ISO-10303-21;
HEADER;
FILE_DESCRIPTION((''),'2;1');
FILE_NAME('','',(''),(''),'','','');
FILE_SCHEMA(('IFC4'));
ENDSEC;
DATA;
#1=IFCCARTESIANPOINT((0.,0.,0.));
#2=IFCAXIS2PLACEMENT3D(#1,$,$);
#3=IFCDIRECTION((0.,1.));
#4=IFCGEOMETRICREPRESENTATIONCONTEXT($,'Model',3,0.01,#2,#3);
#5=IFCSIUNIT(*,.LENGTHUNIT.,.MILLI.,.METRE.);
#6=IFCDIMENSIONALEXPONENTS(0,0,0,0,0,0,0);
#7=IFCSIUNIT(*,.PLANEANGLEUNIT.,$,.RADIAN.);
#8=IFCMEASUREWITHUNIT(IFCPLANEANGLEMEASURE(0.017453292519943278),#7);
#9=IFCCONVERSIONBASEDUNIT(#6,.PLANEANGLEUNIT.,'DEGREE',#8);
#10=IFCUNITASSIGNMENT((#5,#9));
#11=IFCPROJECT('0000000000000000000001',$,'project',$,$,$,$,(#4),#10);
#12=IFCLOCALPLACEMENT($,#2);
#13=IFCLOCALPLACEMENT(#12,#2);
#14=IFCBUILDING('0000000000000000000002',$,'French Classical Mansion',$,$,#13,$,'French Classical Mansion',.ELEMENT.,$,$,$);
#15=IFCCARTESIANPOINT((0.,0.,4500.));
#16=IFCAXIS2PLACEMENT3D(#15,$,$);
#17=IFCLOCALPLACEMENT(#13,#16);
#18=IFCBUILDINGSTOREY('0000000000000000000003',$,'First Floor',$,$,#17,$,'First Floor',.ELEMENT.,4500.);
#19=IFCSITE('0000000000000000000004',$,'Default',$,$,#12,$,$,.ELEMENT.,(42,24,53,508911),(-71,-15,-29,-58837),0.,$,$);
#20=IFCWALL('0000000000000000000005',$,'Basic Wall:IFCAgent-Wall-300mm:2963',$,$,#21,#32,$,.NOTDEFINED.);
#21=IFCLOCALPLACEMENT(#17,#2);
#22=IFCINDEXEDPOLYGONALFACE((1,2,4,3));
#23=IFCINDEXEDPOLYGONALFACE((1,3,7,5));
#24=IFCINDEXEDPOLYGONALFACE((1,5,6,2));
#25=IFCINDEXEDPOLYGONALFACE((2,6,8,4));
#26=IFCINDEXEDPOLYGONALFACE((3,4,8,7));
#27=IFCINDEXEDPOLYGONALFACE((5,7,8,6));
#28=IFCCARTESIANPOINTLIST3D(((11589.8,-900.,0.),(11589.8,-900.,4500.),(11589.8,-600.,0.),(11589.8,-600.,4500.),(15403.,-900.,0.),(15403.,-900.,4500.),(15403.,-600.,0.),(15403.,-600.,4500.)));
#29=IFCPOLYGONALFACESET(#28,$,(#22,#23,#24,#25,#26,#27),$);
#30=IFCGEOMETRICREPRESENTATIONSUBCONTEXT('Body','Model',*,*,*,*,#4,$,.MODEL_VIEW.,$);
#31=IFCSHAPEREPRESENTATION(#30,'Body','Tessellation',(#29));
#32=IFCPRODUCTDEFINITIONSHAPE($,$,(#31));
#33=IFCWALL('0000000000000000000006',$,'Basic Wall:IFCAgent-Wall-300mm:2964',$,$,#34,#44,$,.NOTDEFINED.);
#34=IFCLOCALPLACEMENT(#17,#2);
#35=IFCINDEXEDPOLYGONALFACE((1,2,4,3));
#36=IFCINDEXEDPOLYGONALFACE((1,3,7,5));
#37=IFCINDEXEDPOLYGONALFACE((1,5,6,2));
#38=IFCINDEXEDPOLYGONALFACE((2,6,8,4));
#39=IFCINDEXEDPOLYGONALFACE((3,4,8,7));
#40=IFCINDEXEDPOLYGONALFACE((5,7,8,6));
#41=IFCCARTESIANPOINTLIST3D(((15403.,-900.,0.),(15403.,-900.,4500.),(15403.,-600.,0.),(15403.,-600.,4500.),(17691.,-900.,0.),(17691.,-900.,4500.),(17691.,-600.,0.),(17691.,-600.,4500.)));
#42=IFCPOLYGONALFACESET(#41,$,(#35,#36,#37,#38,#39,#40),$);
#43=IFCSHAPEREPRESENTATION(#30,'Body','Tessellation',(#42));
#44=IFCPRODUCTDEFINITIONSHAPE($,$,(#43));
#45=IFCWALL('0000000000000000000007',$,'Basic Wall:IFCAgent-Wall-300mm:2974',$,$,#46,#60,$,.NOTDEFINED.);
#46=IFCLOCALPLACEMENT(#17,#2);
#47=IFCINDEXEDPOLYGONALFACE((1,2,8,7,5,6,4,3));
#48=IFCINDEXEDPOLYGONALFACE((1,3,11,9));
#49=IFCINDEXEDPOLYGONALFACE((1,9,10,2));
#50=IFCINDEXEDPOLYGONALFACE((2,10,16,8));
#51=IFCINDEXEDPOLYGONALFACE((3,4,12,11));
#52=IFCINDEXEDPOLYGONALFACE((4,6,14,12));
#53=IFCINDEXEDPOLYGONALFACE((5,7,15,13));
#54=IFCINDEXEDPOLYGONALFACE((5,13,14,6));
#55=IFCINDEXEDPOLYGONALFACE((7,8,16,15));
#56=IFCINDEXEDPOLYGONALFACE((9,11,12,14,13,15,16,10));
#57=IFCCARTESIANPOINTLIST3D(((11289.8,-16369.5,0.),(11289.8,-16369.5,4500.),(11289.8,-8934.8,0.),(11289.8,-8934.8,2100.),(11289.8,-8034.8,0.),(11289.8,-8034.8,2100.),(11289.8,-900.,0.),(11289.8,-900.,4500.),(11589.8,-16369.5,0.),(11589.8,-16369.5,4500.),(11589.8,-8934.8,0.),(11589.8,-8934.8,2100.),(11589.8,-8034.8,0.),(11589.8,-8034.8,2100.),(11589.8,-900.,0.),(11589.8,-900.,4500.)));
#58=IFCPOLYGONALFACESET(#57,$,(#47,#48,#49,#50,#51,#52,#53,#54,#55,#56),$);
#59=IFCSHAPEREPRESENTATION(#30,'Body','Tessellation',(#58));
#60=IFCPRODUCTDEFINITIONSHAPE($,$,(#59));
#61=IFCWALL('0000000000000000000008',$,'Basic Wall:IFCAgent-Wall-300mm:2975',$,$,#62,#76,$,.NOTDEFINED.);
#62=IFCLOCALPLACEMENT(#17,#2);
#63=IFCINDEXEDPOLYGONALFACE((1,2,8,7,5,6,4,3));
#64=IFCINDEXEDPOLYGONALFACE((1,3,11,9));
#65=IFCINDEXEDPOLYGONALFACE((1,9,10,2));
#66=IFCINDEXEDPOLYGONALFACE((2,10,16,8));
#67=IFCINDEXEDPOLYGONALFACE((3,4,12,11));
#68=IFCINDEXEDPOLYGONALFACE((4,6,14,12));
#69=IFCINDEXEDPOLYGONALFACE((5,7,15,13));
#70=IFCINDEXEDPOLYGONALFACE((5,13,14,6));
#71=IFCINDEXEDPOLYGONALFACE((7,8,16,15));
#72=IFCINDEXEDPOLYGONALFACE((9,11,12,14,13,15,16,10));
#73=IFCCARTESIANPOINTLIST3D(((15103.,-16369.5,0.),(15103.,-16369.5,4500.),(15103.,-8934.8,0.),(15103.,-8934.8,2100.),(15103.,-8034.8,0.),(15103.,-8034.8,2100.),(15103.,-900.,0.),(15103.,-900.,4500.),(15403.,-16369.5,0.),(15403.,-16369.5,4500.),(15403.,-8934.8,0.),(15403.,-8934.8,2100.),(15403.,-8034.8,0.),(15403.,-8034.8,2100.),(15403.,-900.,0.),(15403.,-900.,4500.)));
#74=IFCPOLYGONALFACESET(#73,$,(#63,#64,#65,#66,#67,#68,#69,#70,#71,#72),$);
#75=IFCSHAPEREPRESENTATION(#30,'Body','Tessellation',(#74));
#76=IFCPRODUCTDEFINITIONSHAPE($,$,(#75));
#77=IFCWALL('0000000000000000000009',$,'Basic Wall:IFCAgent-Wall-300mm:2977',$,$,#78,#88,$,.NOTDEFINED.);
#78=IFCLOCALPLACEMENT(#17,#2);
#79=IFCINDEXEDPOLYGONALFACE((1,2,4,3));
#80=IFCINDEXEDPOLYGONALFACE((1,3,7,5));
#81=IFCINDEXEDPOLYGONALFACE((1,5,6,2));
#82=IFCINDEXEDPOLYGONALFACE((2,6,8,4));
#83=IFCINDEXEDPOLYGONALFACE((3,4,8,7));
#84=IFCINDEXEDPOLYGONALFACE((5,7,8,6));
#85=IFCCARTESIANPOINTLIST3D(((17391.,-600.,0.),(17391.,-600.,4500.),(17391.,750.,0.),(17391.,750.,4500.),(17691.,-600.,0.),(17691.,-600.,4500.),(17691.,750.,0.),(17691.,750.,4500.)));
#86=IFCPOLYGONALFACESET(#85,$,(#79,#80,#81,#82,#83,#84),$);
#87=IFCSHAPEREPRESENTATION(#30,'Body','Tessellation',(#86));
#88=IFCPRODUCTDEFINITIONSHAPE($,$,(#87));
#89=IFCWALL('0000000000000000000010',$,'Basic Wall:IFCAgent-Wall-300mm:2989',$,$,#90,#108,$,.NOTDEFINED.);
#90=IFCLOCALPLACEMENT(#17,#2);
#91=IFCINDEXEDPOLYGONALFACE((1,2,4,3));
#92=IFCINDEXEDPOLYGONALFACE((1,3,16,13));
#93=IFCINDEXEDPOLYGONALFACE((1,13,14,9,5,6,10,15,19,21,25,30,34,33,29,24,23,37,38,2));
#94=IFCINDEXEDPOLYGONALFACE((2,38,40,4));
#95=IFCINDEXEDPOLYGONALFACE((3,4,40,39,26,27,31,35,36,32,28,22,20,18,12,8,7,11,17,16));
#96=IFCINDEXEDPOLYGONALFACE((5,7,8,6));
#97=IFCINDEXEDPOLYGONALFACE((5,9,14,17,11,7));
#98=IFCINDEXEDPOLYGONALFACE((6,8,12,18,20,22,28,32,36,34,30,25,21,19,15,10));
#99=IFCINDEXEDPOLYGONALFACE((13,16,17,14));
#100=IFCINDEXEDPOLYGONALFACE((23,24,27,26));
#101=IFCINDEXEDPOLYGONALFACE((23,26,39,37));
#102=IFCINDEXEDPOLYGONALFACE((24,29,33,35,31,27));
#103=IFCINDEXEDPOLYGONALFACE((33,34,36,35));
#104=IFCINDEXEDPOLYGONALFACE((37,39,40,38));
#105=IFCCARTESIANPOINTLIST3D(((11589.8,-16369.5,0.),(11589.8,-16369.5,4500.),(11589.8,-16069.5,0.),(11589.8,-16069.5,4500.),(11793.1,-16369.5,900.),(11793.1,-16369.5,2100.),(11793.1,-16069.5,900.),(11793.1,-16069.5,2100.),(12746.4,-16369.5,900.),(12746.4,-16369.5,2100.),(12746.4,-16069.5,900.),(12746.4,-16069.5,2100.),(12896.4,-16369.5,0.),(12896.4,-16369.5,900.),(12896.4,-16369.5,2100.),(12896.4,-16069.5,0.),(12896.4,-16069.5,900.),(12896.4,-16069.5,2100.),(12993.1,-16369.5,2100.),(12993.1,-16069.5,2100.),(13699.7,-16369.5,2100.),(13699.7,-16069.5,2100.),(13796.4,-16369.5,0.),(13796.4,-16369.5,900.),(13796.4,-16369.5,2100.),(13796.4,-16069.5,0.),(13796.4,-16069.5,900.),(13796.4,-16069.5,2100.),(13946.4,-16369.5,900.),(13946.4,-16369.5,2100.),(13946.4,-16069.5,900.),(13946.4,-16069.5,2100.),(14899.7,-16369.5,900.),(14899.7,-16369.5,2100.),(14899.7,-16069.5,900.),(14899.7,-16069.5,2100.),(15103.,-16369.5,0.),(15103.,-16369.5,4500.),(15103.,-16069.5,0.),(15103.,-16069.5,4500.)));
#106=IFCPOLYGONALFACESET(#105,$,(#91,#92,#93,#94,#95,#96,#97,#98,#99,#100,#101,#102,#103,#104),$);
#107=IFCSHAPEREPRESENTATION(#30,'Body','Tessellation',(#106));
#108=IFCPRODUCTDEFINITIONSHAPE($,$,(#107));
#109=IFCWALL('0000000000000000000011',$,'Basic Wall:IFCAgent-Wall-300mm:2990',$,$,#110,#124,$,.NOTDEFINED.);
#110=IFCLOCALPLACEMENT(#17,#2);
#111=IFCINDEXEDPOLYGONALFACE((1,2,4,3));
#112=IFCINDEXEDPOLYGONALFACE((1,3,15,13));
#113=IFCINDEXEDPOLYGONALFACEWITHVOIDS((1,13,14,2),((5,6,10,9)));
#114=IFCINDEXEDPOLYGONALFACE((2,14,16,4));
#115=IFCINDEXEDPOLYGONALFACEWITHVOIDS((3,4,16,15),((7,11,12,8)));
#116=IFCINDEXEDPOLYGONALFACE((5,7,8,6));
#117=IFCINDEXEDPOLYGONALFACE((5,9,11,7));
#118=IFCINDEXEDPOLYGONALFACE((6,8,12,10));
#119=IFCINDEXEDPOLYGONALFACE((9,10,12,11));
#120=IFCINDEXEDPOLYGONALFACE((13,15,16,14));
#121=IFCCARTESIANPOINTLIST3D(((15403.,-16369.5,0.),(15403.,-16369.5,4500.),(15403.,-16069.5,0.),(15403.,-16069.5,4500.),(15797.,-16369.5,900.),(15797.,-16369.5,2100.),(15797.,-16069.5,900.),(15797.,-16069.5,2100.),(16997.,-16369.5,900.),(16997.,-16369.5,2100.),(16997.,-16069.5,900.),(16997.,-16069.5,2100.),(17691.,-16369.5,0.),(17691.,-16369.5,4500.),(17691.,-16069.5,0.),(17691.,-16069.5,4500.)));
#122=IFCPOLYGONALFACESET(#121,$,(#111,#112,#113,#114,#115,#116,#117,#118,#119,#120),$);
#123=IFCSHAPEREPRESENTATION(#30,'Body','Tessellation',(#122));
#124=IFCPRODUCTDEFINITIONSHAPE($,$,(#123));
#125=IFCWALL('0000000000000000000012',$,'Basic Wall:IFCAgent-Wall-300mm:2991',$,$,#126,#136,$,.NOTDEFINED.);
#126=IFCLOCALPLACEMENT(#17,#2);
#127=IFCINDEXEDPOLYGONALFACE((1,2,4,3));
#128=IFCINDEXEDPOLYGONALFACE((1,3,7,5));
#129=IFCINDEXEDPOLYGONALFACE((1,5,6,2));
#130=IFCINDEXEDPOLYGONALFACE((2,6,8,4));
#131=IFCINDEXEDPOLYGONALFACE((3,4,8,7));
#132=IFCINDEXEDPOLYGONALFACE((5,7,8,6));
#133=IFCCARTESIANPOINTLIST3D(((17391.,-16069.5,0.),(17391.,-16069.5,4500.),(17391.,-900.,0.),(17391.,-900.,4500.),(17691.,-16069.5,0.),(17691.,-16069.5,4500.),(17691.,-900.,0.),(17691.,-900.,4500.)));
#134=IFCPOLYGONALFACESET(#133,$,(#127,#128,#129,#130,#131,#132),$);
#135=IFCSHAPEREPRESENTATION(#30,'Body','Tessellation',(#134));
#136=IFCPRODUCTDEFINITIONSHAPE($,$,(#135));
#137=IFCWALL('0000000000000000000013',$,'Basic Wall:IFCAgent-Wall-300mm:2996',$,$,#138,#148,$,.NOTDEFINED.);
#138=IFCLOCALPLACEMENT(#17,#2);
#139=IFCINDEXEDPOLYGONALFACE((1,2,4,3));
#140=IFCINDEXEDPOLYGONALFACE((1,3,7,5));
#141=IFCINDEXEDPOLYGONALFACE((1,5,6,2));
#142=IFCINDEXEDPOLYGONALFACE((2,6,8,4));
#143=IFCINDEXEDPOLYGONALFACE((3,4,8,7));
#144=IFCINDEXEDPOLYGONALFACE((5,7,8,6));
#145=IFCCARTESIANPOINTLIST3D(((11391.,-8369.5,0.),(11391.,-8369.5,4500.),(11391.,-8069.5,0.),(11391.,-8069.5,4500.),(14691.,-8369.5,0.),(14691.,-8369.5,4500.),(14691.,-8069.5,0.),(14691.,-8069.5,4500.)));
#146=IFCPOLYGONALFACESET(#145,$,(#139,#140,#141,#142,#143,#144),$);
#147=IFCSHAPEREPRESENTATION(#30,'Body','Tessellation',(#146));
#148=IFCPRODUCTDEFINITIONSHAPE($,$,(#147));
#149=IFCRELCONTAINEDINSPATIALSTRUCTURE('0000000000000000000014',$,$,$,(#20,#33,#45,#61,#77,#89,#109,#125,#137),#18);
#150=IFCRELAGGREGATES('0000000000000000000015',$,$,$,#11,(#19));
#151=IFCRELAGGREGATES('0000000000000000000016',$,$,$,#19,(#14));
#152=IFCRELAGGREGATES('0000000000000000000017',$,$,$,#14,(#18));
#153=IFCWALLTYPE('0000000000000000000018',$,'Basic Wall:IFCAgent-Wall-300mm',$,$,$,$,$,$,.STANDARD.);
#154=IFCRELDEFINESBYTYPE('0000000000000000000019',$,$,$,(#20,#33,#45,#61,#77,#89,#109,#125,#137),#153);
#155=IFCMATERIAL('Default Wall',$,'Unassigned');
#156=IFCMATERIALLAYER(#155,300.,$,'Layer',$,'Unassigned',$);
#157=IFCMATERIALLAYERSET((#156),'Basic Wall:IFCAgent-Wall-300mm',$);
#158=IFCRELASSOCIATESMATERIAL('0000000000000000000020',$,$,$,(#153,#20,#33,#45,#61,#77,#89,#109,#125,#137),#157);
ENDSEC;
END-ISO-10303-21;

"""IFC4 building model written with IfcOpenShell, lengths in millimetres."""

from ifc_helpers import new_model, entity, si_unit, converted_unit, direction, frame, frame_2d, origin, place, context, subcontext, project, spatial, rectangle, extrude, material, layer, layer_set, layer_usage, type_object, element, save


model = new_model("IFC4")

# Units and contexts
model_context = context("Model", 3, precision=0.01, world=origin(), true_north=direction((0.0, 1.0)))
body_context = subcontext(model_context, "Body", "Model", "MODEL_VIEW")
ifc_project = project(units=[si_unit("LENGTHUNIT", "METRE", prefix="MILLI"), converted_unit("PLANEANGLEUNIT", "DEGREE", entity("IfcPlaneAngleMeasure", 0.017453292519943278), si_unit("PLANEANGLEUNIT", "RADIAN"), dimensions=[0, 0, 0, 0, 0, 0, 0])], contexts=[model_context])

# Site, building, storey
site_placement = place(None, origin())
site = spatial("IfcSite", under=ifc_project, at=site_placement, Name="Default", CompositionType="ELEMENT", RefLatitude=(42, 24, 53, 508911), RefLongitude=(-71, -15, -29, -58837), RefElevation=0.0)
building_placement = place(site_placement, origin())
building = spatial("IfcBuilding", under=site, at=building_placement, Name="French Classical Mansion", LongName="French Classical Mansion", CompositionType="ELEMENT")
storey_placement = place(building_placement, frame((0.0, 0.0, 4500.0)))
storey = spatial("IfcBuildingStorey", under=building, at=storey_placement, Name="First Floor", LongName="First Floor", CompositionType="ELEMENT", Elevation=4500.0)

# Walls
ifc_material = material(Name="Default Wall", Category="Unassigned")
ifc_layer = layer(ifc_material, 300.0, Name="Layer", Category="Unassigned")
ifc_layer_set = layer_set([ifc_layer], Name="Basic Wall:IFCAgent-Wall-300mm")
ifc_layer_usage_1 = layer_usage(ifc_layer_set, "AXIS2", "NEGATIVE", 150.0)
wall_type = type_object("IfcWallType", Name="Basic Wall:IFCAgent-Wall-300mm", PredefinedType="STANDARD", material=ifc_layer_set)
wall_1_placement = place(storey_placement, frame((11589.8, -750.0, 0.0)))
element("IfcWall", 1, at=wall_1_placement, inside=storey, type_object=wall_type, material=ifc_layer_usage_1, Name="Basic Wall:IFCAgent-Wall-300mm:2963", PredefinedType="NOTDEFINED", context=body_context, shape_type="SweptSolid", body=[
    extrude(rectangle(XDim=3813.3, YDim=300.0, at=frame_2d((1906.6, 0.0), x_axis=(-1.0, 0.0))), origin(), (0.0, 0.0, 1.0), 4500.0),
])
ifc_layer_usage_2 = layer_usage(ifc_layer_set, "AXIS2", "NEGATIVE", 150.0)
wall_2_placement = place(storey_placement, frame((15403.0, -750.0, 0.0)))
element("IfcWall", 2, at=wall_2_placement, inside=storey, type_object=wall_type, material=ifc_layer_usage_2, Name="Basic Wall:IFCAgent-Wall-300mm:2964", PredefinedType="NOTDEFINED", context=body_context, shape_type="SweptSolid", body=[
    extrude(rectangle(XDim=2288.0, YDim=300.0, at=frame_2d((1144.0, 0.0), x_axis=(-1.0, 0.0))), origin(), (0.0, 0.0, 1.0), 4500.0),
])

# Walls, openings
ifc_layer_usage_3 = layer_usage(ifc_layer_set, "AXIS2", "NEGATIVE", 150.0)
wall_3_placement = place(storey_placement, frame((11439.8, -16369.5, 0.0), z_axis=(0.0, 0.0, 1.0), x_axis=(0.0, 1.0, 0.0)))
wall_3 = element("IfcWall", 3, at=wall_3_placement, inside=storey, type_object=wall_type, material=ifc_layer_usage_3, Name="Basic Wall:IFCAgent-Wall-300mm:2974", PredefinedType="NOTDEFINED", context=body_context, shape_type="SweptSolid", body=[
    extrude(rectangle(XDim=15469.5, YDim=300.0, at=frame_2d((7734.8, 0.0), x_axis=(-1.0, 0.0))), origin(), (0.0, 0.0, 1.0), 4500.0),
])
opening_1_placement = place(wall_3_placement, origin())
element("IfcOpeningElement", 4, at=opening_1_placement, cuts=wall_3, PredefinedType="OPENING", context=body_context, shape_type="SweptSolid", body=[
    extrude(rectangle(XDim=2100.0, YDim=900.0, at=frame_2d((0.0, 0.0), x_axis=(1.0, 0.0))), frame((7884.7, -150.0, 1050.0), z_axis=(0.0, 1.0, 0.0), x_axis=(0.0, 0.0, -1.0)), (0.0, 0.0, 1.0), 300.0),
])
ifc_layer_usage_4 = layer_usage(ifc_layer_set, "AXIS2", "NEGATIVE", 150.0)
wall_4_placement = place(storey_placement, frame((15253.0, -16369.5, 0.0), z_axis=(0.0, 0.0, 1.0), x_axis=(0.0, 1.0, 0.0)))
wall_4 = element("IfcWall", 5, at=wall_4_placement, inside=storey, type_object=wall_type, material=ifc_layer_usage_4, Name="Basic Wall:IFCAgent-Wall-300mm:2975", PredefinedType="NOTDEFINED", context=body_context, shape_type="SweptSolid", body=[
    extrude(rectangle(XDim=15469.5, YDim=300.0, at=frame_2d((7734.8, 0.0), x_axis=(-1.0, 0.0))), origin(), (0.0, 0.0, 1.0), 4500.0),
])
opening_2_placement = place(wall_4_placement, origin())
element("IfcOpeningElement", 6, at=opening_2_placement, cuts=wall_4, PredefinedType="OPENING", context=body_context, shape_type="SweptSolid", body=[
    extrude(rectangle(XDim=2100.0, YDim=900.0, at=frame_2d((0.0, 0.0), x_axis=(1.0, 0.0))), frame((7884.7, -150.0, 1050.0), z_axis=(0.0, 1.0, 0.0), x_axis=(0.0, 0.0, -1.0)), (0.0, 0.0, 1.0), 300.0),
])

# Wall
ifc_layer_usage_5 = layer_usage(ifc_layer_set, "AXIS2", "NEGATIVE", 150.0)
wall_5_placement = place(storey_placement, frame((17541.0, -600.0, 0.0), z_axis=(0.0, 0.0, 1.0), x_axis=(0.0, 1.0, 0.0)))
element("IfcWall", 7, at=wall_5_placement, inside=storey, type_object=wall_type, material=ifc_layer_usage_5, Name="Basic Wall:IFCAgent-Wall-300mm:2977", PredefinedType="NOTDEFINED", context=body_context, shape_type="SweptSolid", body=[
    extrude(rectangle(XDim=1350.0, YDim=300.0, at=frame_2d((675.0, 0.0), x_axis=(-1.0, 0.0))), origin(), (0.0, 0.0, 1.0), 4500.0),
])

# Wall, openings
ifc_layer_usage_6 = layer_usage(ifc_layer_set, "AXIS2", "NEGATIVE", 150.0)
wall_6_placement = place(storey_placement, frame((11589.8, -16219.5, 0.0)))
wall_6 = element("IfcWall", 8, at=wall_6_placement, inside=storey, type_object=wall_type, material=ifc_layer_usage_6, Name="Basic Wall:IFCAgent-Wall-300mm:2989", PredefinedType="NOTDEFINED", context=body_context, shape_type="SweptSolid", body=[
    extrude(rectangle(XDim=3513.3, YDim=300.0, at=frame_2d((1756.6, 0.0), x_axis=(-1.0, 0.0))), origin(), (0.0, 0.0, 1.0), 4500.0),
])
opening_3_placement = place(wall_6_placement, origin())
element("IfcOpeningElement", 9, at=opening_3_placement, cuts=wall_6, PredefinedType="OPENING", context=body_context, shape_type="SweptSolid", body=[
    extrude(rectangle(XDim=2100.0, YDim=900.0, at=frame_2d((0.0, 0.0), x_axis=(1.0, 0.0))), frame((1756.6, -150.0, 1050.0), z_axis=(0.0, 1.0, 0.0), x_axis=(0.0, 0.0, -1.0)), (0.0, 0.0, 1.0), 300.0),
])
opening_4_placement = place(wall_6_placement, origin())
element("IfcOpeningElement", 10, at=opening_4_placement, cuts=wall_6, PredefinedType="OPENING", context=body_context, shape_type="SweptSolid", body=[
    extrude(rectangle(XDim=1200.0, YDim=1200.0, at=frame_2d((0.0, 0.0), x_axis=(1.0, 0.0))), frame((803.3, -150.0, 1500.0), z_axis=(0.0, 1.0, 0.0), x_axis=(0.0, 0.0, -1.0)), (0.0, 0.0, 1.0), 300.0),
])
opening_5_placement = place(wall_6_placement, origin())
element("IfcOpeningElement", 11, at=opening_5_placement, cuts=wall_6, PredefinedType="OPENING", context=body_context, shape_type="SweptSolid", body=[
    extrude(rectangle(XDim=1200.0, YDim=1200.0, at=frame_2d((0.0, 0.0), x_axis=(1.0, 0.0))), frame((1756.6, -150.0, 1500.0), z_axis=(0.0, 1.0, 0.0), x_axis=(0.0, 0.0, -1.0)), (0.0, 0.0, 1.0), 300.0),
])
opening_6_placement = place(wall_6_placement, origin())
element("IfcOpeningElement", 12, at=opening_6_placement, cuts=wall_6, PredefinedType="OPENING", context=body_context, shape_type="SweptSolid", body=[
    extrude(rectangle(XDim=1200.0, YDim=1200.0, at=frame_2d((0.0, 0.0), x_axis=(1.0, 0.0))), frame((2709.9, -150.0, 1500.0), z_axis=(0.0, 1.0, 0.0), x_axis=(0.0, 0.0, -1.0)), (0.0, 0.0, 1.0), 300.0),
])

# Wall, opening
ifc_layer_usage_7 = layer_usage(ifc_layer_set, "AXIS2", "NEGATIVE", 150.0)
wall_7_placement = place(storey_placement, frame((15403.0, -16219.5, 0.0)))
wall_7 = element("IfcWall", 13, at=wall_7_placement, inside=storey, type_object=wall_type, material=ifc_layer_usage_7, Name="Basic Wall:IFCAgent-Wall-300mm:2990", PredefinedType="NOTDEFINED", context=body_context, shape_type="SweptSolid", body=[
    extrude(rectangle(XDim=2288.0, YDim=300.0, at=frame_2d((1144.0, 0.0), x_axis=(-1.0, 0.0))), origin(), (0.0, 0.0, 1.0), 4500.0),
])
opening_7_placement = place(wall_7_placement, origin())
element("IfcOpeningElement", 14, at=opening_7_placement, cuts=wall_7, PredefinedType="OPENING", context=body_context, shape_type="SweptSolid", body=[
    extrude(rectangle(XDim=1200.0, YDim=1200.0, at=frame_2d((0.0, 0.0), x_axis=(1.0, 0.0))), frame((994.0, -150.0, 1500.0), z_axis=(0.0, 1.0, 0.0), x_axis=(0.0, 0.0, -1.0)), (0.0, 0.0, 1.0), 300.0),
])

# Walls
ifc_layer_usage_8 = layer_usage(ifc_layer_set, "AXIS2", "NEGATIVE", 150.0)
wall_8_placement = place(storey_placement, frame((17541.0, -16069.5, 0.0), z_axis=(0.0, 0.0, 1.0), x_axis=(0.0, 1.0, 0.0)))
element("IfcWall", 15, at=wall_8_placement, inside=storey, type_object=wall_type, material=ifc_layer_usage_8, Name="Basic Wall:IFCAgent-Wall-300mm:2991", PredefinedType="NOTDEFINED", context=body_context, shape_type="SweptSolid", body=[
    extrude(rectangle(XDim=15169.5, YDim=300.0, at=frame_2d((7584.8, 0.0), x_axis=(-1.0, 0.0))), origin(), (0.0, 0.0, 1.0), 4500.0),
])
ifc_layer_usage_9 = layer_usage(ifc_layer_set, "AXIS2", "NEGATIVE", 150.0)
wall_9_placement = place(storey_placement, frame((11391.0, -8219.5, 0.0)))
element("IfcWall", 16, at=wall_9_placement, inside=storey, type_object=wall_type, material=ifc_layer_usage_9, Name="Basic Wall:IFCAgent-Wall-300mm:2996", PredefinedType="NOTDEFINED", context=body_context, shape_type="SweptSolid", body=[
    extrude(rectangle(XDim=3300.0, YDim=300.0, at=frame_2d((1650.0, 0.0), x_axis=(-1.0, 0.0))), origin(), (0.0, 0.0, 1.0), 4500.0),
])

save(model, "model.ifc")
